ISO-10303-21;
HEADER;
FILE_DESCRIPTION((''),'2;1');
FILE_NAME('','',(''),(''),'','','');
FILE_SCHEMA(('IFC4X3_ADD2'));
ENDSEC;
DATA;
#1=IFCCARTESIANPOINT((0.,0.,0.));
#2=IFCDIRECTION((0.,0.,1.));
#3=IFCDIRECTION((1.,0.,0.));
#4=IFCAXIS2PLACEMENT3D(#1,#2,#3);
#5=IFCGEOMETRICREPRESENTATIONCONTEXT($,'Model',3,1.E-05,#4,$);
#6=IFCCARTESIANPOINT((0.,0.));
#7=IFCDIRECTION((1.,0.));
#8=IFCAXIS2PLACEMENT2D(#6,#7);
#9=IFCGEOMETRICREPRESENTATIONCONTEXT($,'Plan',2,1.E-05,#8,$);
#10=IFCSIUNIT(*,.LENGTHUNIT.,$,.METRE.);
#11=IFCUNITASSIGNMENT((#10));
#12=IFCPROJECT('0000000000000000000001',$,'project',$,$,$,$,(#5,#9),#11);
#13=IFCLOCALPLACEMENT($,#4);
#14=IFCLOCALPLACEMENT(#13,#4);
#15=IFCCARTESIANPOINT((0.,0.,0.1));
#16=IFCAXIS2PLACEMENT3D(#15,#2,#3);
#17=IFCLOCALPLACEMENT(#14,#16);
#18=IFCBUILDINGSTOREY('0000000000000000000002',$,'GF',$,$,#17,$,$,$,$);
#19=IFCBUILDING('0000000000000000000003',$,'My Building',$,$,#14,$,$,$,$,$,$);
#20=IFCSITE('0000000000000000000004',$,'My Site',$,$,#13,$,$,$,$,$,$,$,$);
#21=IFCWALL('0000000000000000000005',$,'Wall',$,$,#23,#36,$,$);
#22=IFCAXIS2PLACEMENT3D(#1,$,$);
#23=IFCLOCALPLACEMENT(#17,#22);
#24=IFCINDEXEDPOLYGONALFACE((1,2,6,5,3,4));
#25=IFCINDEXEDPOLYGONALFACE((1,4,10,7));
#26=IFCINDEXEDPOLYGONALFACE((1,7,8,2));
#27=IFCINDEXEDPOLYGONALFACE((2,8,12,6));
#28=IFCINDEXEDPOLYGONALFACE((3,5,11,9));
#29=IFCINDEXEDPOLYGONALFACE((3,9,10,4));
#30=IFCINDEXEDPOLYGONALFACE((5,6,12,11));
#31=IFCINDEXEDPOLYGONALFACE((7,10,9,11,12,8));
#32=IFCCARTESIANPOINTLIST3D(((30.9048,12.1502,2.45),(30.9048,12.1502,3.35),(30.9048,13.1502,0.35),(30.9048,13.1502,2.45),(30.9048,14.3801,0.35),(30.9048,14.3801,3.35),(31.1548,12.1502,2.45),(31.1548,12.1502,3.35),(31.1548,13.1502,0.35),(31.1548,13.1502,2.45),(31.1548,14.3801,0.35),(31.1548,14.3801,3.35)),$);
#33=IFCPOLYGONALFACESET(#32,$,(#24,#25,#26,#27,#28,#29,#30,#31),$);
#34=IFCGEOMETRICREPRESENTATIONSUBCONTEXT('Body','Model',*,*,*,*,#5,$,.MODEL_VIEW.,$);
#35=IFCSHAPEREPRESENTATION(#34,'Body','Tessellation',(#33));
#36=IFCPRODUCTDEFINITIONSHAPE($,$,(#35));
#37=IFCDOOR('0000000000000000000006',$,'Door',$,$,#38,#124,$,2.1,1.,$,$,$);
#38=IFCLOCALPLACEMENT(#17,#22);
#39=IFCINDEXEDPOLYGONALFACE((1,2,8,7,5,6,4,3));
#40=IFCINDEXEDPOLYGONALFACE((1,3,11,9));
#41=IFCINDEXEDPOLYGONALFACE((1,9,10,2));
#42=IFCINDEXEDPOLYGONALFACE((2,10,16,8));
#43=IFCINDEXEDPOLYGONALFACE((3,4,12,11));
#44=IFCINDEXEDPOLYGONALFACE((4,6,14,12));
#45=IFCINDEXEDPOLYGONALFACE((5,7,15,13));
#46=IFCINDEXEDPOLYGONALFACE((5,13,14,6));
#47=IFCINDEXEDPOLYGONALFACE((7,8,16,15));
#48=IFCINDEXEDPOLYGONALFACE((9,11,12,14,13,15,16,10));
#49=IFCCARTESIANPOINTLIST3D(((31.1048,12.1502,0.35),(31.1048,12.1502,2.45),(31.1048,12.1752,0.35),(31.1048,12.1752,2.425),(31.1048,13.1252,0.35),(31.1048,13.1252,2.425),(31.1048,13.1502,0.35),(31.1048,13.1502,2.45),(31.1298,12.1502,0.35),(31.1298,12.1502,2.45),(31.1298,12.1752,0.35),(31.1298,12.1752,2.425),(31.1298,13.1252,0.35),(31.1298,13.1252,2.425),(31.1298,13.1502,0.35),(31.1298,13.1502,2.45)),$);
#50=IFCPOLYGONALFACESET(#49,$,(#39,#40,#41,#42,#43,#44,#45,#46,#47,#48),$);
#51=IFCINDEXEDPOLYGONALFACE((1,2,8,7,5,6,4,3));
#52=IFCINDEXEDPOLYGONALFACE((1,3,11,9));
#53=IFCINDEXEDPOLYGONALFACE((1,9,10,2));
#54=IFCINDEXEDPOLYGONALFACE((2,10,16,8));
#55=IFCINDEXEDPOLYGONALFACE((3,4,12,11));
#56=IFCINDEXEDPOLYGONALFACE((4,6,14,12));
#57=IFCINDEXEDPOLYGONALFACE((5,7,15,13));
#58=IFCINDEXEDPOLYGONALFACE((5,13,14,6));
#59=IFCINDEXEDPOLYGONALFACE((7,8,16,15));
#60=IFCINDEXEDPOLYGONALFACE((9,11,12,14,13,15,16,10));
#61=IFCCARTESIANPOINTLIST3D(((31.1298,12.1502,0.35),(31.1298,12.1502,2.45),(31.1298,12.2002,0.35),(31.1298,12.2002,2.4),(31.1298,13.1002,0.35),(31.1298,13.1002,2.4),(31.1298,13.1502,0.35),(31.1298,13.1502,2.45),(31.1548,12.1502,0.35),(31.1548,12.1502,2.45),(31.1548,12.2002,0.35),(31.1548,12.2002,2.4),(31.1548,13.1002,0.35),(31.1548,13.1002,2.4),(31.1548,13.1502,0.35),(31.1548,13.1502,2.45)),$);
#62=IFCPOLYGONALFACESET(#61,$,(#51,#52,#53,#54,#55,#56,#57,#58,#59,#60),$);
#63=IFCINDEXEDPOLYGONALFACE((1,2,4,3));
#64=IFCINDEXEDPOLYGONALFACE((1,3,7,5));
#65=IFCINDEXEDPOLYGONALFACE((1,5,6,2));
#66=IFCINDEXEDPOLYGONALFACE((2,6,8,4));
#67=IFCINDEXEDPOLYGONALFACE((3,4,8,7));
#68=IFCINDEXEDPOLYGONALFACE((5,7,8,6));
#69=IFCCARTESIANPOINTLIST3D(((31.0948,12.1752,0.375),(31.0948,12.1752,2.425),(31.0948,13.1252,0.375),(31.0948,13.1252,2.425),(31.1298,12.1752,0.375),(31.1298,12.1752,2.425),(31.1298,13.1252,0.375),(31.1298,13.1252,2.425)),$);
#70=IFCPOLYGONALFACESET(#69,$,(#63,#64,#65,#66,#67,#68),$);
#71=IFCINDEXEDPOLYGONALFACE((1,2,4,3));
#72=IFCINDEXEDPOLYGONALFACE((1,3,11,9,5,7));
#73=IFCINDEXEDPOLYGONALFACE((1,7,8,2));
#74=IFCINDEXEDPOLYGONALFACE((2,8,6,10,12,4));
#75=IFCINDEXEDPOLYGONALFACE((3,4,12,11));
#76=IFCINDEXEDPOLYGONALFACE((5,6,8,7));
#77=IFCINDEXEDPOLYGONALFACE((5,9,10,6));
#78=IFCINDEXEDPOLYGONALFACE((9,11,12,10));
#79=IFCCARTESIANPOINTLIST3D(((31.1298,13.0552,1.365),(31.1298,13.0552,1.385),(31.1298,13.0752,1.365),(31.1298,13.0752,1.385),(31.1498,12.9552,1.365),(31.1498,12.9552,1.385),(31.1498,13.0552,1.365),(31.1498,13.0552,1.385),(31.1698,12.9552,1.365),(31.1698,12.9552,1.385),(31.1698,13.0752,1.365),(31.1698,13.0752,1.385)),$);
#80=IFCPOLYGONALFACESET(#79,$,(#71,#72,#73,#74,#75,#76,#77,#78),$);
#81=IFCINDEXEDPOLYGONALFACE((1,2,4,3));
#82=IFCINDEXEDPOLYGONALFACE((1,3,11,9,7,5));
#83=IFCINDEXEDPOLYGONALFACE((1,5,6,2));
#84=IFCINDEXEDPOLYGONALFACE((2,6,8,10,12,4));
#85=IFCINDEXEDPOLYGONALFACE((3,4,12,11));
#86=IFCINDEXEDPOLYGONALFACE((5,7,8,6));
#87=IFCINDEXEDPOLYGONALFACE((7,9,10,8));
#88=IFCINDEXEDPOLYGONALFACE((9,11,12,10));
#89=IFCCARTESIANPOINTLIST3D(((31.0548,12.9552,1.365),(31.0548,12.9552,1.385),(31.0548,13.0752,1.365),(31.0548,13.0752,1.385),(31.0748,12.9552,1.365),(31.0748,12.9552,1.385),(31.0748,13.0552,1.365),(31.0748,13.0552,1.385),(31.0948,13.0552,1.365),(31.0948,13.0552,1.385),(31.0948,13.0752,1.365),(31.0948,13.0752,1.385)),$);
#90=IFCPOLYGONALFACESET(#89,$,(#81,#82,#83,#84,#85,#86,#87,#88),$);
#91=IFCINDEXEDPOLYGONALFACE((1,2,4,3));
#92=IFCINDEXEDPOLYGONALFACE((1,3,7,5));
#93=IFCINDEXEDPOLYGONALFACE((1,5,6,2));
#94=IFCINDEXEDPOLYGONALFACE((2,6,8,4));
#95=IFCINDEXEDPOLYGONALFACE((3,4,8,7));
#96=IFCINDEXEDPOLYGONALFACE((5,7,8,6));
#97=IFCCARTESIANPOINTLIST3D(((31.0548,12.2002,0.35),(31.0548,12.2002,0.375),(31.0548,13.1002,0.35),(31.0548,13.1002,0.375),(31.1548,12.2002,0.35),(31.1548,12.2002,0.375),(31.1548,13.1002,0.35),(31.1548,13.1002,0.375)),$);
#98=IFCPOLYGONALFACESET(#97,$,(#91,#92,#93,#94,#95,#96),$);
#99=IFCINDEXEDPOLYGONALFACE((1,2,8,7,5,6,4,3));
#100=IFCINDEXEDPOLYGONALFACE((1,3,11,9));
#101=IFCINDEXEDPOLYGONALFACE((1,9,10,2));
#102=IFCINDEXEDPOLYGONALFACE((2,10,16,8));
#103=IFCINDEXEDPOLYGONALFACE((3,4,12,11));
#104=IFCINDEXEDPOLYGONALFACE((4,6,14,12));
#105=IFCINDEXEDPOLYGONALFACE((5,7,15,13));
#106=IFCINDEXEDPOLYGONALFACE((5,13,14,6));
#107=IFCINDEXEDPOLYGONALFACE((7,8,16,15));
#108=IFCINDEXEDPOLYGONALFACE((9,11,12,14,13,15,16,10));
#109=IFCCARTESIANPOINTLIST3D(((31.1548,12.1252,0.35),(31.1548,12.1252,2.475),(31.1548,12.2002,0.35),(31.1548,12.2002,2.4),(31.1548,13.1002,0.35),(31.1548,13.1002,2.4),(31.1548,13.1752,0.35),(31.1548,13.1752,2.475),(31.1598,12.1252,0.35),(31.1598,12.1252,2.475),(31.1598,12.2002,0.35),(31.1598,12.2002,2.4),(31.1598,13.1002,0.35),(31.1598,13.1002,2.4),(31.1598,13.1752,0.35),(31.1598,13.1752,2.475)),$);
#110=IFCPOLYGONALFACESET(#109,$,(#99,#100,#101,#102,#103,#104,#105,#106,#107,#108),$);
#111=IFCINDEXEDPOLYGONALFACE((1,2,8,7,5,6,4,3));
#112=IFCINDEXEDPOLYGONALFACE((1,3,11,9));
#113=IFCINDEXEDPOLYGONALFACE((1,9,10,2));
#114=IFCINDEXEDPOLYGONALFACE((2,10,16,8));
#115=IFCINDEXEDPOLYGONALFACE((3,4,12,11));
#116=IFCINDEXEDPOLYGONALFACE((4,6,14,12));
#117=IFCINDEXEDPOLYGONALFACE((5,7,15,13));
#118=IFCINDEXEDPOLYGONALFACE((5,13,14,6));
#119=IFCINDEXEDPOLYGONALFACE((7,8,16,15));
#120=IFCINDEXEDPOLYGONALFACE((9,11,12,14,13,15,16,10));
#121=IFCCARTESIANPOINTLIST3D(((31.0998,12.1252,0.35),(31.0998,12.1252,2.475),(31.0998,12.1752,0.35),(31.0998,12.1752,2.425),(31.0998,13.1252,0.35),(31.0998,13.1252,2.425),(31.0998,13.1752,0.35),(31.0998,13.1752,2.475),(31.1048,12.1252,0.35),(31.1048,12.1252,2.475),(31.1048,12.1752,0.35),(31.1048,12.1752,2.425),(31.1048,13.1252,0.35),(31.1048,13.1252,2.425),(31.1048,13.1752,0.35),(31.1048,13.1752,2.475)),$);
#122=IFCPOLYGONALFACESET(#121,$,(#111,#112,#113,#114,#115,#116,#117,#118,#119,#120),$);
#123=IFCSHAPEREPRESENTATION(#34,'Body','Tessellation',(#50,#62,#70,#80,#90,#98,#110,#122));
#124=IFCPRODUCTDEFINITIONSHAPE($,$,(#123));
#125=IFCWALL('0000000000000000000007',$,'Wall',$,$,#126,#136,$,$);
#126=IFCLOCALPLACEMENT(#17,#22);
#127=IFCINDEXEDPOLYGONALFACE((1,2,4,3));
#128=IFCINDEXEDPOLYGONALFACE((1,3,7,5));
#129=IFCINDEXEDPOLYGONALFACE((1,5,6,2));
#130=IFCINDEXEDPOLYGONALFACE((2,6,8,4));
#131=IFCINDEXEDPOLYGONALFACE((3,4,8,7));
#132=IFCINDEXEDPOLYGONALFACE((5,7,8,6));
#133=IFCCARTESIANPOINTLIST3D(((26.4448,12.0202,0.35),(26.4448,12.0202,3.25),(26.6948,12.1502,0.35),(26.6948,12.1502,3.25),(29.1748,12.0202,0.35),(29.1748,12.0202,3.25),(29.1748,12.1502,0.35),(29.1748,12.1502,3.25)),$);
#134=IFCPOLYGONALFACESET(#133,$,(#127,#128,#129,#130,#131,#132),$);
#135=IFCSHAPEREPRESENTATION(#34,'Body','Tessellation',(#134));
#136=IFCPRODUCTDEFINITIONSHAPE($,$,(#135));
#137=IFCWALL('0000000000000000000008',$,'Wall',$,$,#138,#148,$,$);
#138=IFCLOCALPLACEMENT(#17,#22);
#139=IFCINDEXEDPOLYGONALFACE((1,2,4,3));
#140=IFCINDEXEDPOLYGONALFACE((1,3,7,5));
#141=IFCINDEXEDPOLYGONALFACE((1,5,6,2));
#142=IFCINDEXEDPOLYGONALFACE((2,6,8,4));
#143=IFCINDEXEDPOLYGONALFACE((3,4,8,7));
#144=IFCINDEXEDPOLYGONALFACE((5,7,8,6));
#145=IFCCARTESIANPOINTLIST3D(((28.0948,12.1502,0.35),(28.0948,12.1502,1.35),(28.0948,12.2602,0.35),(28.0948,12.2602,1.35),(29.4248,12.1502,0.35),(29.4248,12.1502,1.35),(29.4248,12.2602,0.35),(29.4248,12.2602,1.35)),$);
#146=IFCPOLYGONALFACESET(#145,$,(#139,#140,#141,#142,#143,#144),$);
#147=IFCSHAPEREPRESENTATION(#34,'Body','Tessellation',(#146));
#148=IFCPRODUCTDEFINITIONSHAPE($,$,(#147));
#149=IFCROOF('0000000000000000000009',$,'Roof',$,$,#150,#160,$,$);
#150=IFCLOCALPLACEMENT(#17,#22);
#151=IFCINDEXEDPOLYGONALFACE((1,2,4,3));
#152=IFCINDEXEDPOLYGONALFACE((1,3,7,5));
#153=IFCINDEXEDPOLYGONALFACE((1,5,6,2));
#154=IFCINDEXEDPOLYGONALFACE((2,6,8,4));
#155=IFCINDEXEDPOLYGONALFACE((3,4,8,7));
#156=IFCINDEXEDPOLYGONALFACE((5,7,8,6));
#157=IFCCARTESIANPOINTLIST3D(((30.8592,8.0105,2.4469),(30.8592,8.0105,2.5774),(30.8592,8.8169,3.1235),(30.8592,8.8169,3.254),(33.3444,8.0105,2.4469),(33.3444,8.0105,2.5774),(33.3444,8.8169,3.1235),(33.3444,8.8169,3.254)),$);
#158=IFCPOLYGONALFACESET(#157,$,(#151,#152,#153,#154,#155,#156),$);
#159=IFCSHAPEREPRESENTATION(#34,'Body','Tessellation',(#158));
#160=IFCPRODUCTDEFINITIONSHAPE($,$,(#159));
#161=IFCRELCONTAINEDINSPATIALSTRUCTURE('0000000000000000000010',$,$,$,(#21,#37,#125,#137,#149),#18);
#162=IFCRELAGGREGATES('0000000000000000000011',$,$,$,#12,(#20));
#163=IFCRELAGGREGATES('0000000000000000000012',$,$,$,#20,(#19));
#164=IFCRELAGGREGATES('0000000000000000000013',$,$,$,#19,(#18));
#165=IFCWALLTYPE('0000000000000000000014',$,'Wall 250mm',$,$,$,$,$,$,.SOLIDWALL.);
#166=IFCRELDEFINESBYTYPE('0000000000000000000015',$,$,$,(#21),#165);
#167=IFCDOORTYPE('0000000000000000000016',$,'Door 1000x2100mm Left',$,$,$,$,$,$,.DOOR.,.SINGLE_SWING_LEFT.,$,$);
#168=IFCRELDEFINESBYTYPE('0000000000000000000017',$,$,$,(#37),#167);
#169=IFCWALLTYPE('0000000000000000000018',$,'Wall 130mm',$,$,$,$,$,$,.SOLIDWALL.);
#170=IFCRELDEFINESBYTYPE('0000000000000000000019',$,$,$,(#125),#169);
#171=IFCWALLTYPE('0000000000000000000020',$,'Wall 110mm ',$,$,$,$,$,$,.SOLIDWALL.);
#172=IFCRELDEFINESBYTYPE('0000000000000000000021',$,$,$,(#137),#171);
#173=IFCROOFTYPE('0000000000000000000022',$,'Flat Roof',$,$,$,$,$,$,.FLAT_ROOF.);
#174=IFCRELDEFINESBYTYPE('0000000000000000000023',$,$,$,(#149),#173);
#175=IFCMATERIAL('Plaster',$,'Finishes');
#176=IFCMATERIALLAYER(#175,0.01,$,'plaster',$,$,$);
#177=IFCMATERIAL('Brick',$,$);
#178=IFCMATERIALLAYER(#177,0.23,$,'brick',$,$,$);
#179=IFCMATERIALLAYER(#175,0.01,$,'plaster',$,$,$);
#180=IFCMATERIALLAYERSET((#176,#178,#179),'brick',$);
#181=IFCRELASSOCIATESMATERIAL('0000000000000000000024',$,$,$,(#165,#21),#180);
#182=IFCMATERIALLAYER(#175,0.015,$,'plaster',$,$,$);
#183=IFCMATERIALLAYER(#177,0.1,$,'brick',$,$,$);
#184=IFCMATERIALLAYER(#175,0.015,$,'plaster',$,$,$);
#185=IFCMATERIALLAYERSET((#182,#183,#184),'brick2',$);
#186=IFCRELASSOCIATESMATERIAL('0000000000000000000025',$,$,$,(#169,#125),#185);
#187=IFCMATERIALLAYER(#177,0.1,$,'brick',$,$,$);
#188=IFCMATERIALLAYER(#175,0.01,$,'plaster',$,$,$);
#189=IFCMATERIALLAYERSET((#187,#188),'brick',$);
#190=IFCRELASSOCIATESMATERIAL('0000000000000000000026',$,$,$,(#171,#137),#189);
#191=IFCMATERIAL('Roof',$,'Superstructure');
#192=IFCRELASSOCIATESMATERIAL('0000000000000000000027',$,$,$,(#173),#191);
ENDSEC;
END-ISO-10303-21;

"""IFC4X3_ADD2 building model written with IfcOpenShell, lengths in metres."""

from ifc_helpers import new_model, entity, si_unit, frame, origin_with_axes, origin_2d_with_axis, place, context, subcontext, project, spatial, line, indexed_curve, outline, extrude, shape, source, transform, mapped, material, layer, layer_set, layer_usage, type_object, type_shapes, element, fill, save


model = new_model("IFC4X3_ADD2")

# Units and contexts
model_context = context("Model", 3, precision=1e-05, world=origin_with_axes())
plan_context = context("Plan", 2, precision=1e-05, world=origin_2d_with_axis())
body_context_1 = subcontext(model_context, "Body", "Model", "MODEL_VIEW")
body_context_2 = subcontext(plan_context, "Body", "Plan", "PLAN_VIEW")
ifc_project = project(units=[si_unit("LENGTHUNIT", "METRE")], contexts=[model_context, plan_context])

# Site, building, storey
site_placement = place(None, origin_with_axes())
site = spatial("IfcSite", under=ifc_project, at=site_placement, Name="My Site")
building_placement = place(site_placement, origin_with_axes())
building = spatial("IfcBuilding", under=site, at=building_placement, Name="My Building")
storey_placement = place(building_placement, frame((0.0, 0.0, 0.1), z_axis=(0.0, 0.0, 1.0), x_axis=(1.0, 0.0, 0.0)))
storey = spatial("IfcBuildingStorey", under=building, at=storey_placement, Name="GF")

# Shared definitions
ifc_material_1 = material(Name="Plaster", Category="Finishes")
ifc_layer_1 = layer(ifc_material_1, 0.01, Name="plaster")
ifc_material_2 = material(Name="Brick")
ifc_layer_2 = layer(ifc_material_2, 0.23, Name="brick")
ifc_layer_3 = layer(ifc_material_1, 0.01, Name="plaster")
ifc_layer_set_1 = layer_set([ifc_layer_1, ifc_layer_2, ifc_layer_3], Name="brick")
wall_type_1 = type_object("IfcWallType", Name="Wall 250mm", PredefinedType="SOLIDWALL", material=ifc_layer_set_1)

# Wall, opening, door
ifc_layer_usage_1 = layer_usage(ifc_layer_set_1, "AXIS2", "POSITIVE", 0.0)
wall_1_placement = place(storey_placement, frame((31.1548, 12.1502, 0.35), z_axis=(0.0, 0.0, 1.0), x_axis=(0.000001, 1.0, 0.0)))
wall_1 = element("IfcWall", 1, at=wall_1_placement, inside=storey, type_object=wall_type_1, material=ifc_layer_usage_1, Name="Wall", context=body_context_1, shape_type="SweptSolid", body=[
    extrude(outline(indexed_curve([(0.0, 0.0), (0.0, 0.25), (2.2299, 0.25), (2.2299, 0.0)], segments=[line(1, 2, 3, 4, 1)])), origin_with_axes(), (0.0, 0.0, 1.0), 3.0),
])
shared_shape_1 = source(origin_with_axes(), body_context_1, "Body", "SweptSolid", [
    extrude(outline(indexed_curve([(0.0, 0.0), (1.0, 0.0), (1.0, 2.1), (0.0, 2.1)], segments=[line(1, 2, 3, 4, 1)])), frame((0.0, -0.6, 0.0), z_axis=(0.0, -1.0, 0.0), x_axis=(1.0, 0.0, 0.0)), (0.0, 0.0, -1.0), 1.2),
])
opening_1_placement = place(wall_1_placement, frame((0.0, 0.0, 0.0), z_axis=(0.0, 0.0, 1.0), x_axis=(1.0, 0.0, 0.0)))
opening_1 = element("IfcOpeningElement", 2, at=opening_1_placement, cuts=wall_1, PredefinedType="OPENING", context=body_context_1, shape_type="MappedRepresentation", body=[
    mapped(shared_shape_1, transform((0.0, 0.0, 0.0), x_axis=(1.0, 0.0, 0.0), y_axis=(0.0, 1.0, 0.0), z_axis=(0.0, 0.0, 1.0), scale=1.0)),
])
door_type_1 = type_object("IfcDoorType", Name="Door 1000x2100mm Left", OperationType="SINGLE_SWING_LEFT", PredefinedType="DOOR")
shared_shape_2 = source(origin_with_axes(), body_context_1, "Body", "SweptSolid", [
    extrude(outline(indexed_curve([(0.0, 0.0), (0.0, 2.1), (1.0, 2.1), (1.0, 0.0), (0.975, 0.0), (0.975, 2.075), (0.025, 2.075), (0.025, 0.0)], segments=[line(1, 2, 3, 4, 5, 6, 7, 8, 1)])), frame((0.0, 0.025, 0.0), z_axis=(0.0, -1.0, 0.0), x_axis=(1.0, 0.0, 0.0)), (0.0, 0.0, -1.0), 0.025),
    extrude(outline(indexed_curve([(0.0, 0.0), (0.0, 2.1), (1.0, 2.1), (1.0, 0.0), (0.95, 0.0), (0.95, 2.05), (0.05, 2.05), (0.05, 0.0)], segments=[line(1, 2, 3, 4, 5, 6, 7, 8, 1)])), frame((0.0, 0.0, 0.0), z_axis=(0.0, -1.0, 0.0), x_axis=(1.0, 0.0, 0.0)), (0.0, 0.0, -1.0), 0.025),
    extrude(outline(indexed_curve([(0.0, 0.0), (0.95, 0.0), (0.95, 0.035), (0.0, 0.035)], segments=[line(1, 2, 3, 4, 1)])), frame((0.025, 0.025, 0.025), z_axis=(0.0, 0.0, 1.0), x_axis=(1.0, 0.0, 0.0)), (0.0, 0.0, 1.0), 2.05),
    extrude(outline(indexed_curve([(0.0, 0.0), (0.0, -0.04), (-0.12, -0.04), (-0.12, -0.02), (-0.02, -0.02), (-0.02, 0.0)], segments=[line(1, 2, 3, 4, 5, 6, 1)])), frame((0.925, 0.025, 1.015), z_axis=(0.0, 0.0, 1.0), x_axis=(1.0, 0.0, 0.0)), (0.0, 0.0, 1.0), 0.02),
    extrude(outline(indexed_curve([(0.0, 0.0), (0.0, 0.04), (-0.12, 0.04), (-0.12, 0.02), (-0.02, 0.02), (-0.02, 0.0)], segments=[line(1, 2, 3, 4, 5, 6, 1)])), frame((0.925, 0.06, 1.015), z_axis=(0.0, 0.0, 1.0), x_axis=(1.0, 0.0, 0.0)), (0.0, 0.0, 1.0), 0.02),
    extrude(outline(indexed_curve([(0.0, 0.0), (0.9, 0.0), (0.9, 0.1), (0.0, 0.1)], segments=[line(1, 2, 3, 4, 1)])), frame((0.05, 0.0, 0.0), z_axis=(0.0, 0.0, 1.0), x_axis=(1.0, 0.0, 0.0)), (0.0, 0.0, 1.0), 0.025),
    extrude(outline(indexed_curve([(0.0, 0.0), (0.0, 2.125), (1.05, 2.125), (1.05, 0.0), (0.975, 0.0), (0.975, 2.05), (0.075, 2.05), (0.075, 0.0)], segments=[line(1, 2, 3, 4, 5, 6, 7, 8, 1)])), frame((-0.025, -0.005, 0.0), z_axis=(0.0, -1.0, 0.0), x_axis=(1.0, 0.0, 0.0)), (0.0, 0.0, -1.0), 0.005),
    extrude(outline(indexed_curve([(0.0, 0.0), (0.0, 2.125), (1.05, 2.125), (1.05, 0.0), (1.0, 0.0), (1.0, 2.075), (0.05, 2.075), (0.05, 0.0)], segments=[line(1, 2, 3, 4, 5, 6, 7, 8, 1)])), frame((-0.025, 0.05, 0.0), z_axis=(0.0, -1.0, 0.0), x_axis=(1.0, 0.0, 0.0)), (0.0, 0.0, -1.0), 0.005),
])
shared_shape_3 = source(origin_with_axes(), body_context_2, "Body", "Curve2D", [
    entity("IfcIndexedPolyCurve", entity("IfcCartesianPointList2D", [[0.0, 0.0], [0.0, 0.05], [0.025, 0.05], [0.025, 0.025], [0.05, 0.025], [0.05, 0.0]]), [entity("IfcLineIndex", [1, 2, 3, 4, 5, 6, 1])]),
    entity("IfcIndexedPolyCurve", entity("IfcCartesianPointList2D", [[1.0, 0.0], [1.0, 0.05], [0.975, 0.05], [0.975, 0.025], [0.95, 0.025], [0.95, 0.0]]), [entity("IfcLineIndex", [1, 2, 3, 4, 5, 6, 1])]),
    entity("IfcTrimmedCurve", entity("IfcEllipse", entity("IfcAxis2Placement2D", entity("IfcCartesianPoint", [0.06, 0.05]), entity("IfcDirection", [1.0, 0.0])), 0.915, 0.95), [entity("IfcCartesianPoint", [0.975, 0.05])], [entity("IfcCartesianPoint", [0.06, 1.0])], True, "CARTESIAN"),
    entity("IfcIndexedPolyCurve", entity("IfcCartesianPointList2D", [[0.025, 0.05], [0.06, 0.05], [0.06, 1.0], [0.025, 1.0]]), [entity("IfcLineIndex", [1, 2, 3, 4, 1])]),
])
type_shapes(door_type_1, [shared_shape_2, shared_shape_3])
door_1_placement = place(opening_1_placement, frame((0.0, 0.0, 0.0), z_axis=(0.0, 0.0, 1.0), x_axis=(1.0, 0.0, 0.0)))
door_1 = element("IfcDoor", 3, at=door_1_placement, inside=storey, type_object=door_type_1, Name="Door", OverallHeight=2.1, OverallWidth=1.0, shapes=[
    shape(body_context_1, "Body", "MappedRepresentation", [mapped(shared_shape_2, transform((0.0, 0.0, 0.0), x_axis=(1.0, 0.0, 0.0), y_axis=(0.0, 1.0, 0.0), z_axis=(0.0, 0.0, 1.0), scale=1.0))]),
    shape(body_context_2, "Body", "MappedRepresentation", [mapped(shared_shape_3, transform((0.0, 0.0, 0.0), x_axis=(1.0, 0.0, 0.0), y_axis=(0.0, 1.0, 0.0), z_axis=(0.0, 0.0, 1.0), scale=1.0))]),
])
fill(opening_1, door_1)

# Walls
ifc_layer_4 = layer(ifc_material_1, 0.015, Name="plaster")
ifc_layer_5 = layer(ifc_material_2, 0.1, Name="brick")
ifc_layer_6 = layer(ifc_material_1, 0.015, Name="plaster")
ifc_layer_set_2 = layer_set([ifc_layer_4, ifc_layer_5, ifc_layer_6], Name="brick2")
ifc_layer_usage_2 = layer_usage(ifc_layer_set_2, "AXIS2", "POSITIVE", 0.0)
wall_type_2 = type_object("IfcWallType", Name="Wall 130mm", PredefinedType="SOLIDWALL", material=ifc_layer_set_2)
wall_2_placement = place(storey_placement, frame((29.4248, 12.1502, 0.35), z_axis=(0.0, 0.0, 1.0), x_axis=(-1.0, 0.0, 0.0)))
element("IfcWall", 4, at=wall_2_placement, inside=storey, type_object=wall_type_2, material=ifc_layer_usage_2, Name="Wall", context=body_context_1, shape_type="SweptSolid", body=[
    extrude(outline(indexed_curve([(0.25, 0.0), (0.25, 0.13), (2.98, 0.13), (2.73, 0.0)], segments=[line(1, 2, 3, 4, 1)])), origin_with_axes(), (0.0, 0.0, 1.0), 2.9),
])
ifc_layer_7 = layer(ifc_material_2, 0.1, Name="brick")
ifc_layer_8 = layer(ifc_material_1, 0.01, Name="plaster")
ifc_layer_set_3 = layer_set([ifc_layer_7, ifc_layer_8], Name="brick")
ifc_layer_usage_3 = layer_usage(ifc_layer_set_3, "AXIS2", "NEGATIVE", 0.0)
wall_type_3 = type_object("IfcWallType", Name="Wall 110mm ", PredefinedType="SOLIDWALL", material=ifc_layer_set_3)
wall_3_placement = place(storey_placement, frame((29.4248, 12.1502, 0.35), z_axis=(0.0, 0.0, 1.0), x_axis=(-1.0, 0.0, 0.0)))
element("IfcWall", 5, at=wall_3_placement, inside=storey, type_object=wall_type_3, material=ifc_layer_usage_3, Name="Wall", context=body_context_1, shape_type="SweptSolid", body=[
    extrude(outline(indexed_curve([(0.0, -0.11), (0.0, 0.0), (1.33, 0.0), (1.33, -0.11)], segments=[line(1, 2, 3, 4, 1)])), origin_with_axes(), (0.0, 0.0, 1.0), 1.0),
])

# Roof
ifc_material_3 = material(Name="Roof", Category="Superstructure")
roof_type = type_object("IfcRoofType", Name="Flat Roof", PredefinedType="FLAT_ROOF", material=ifc_material_3)
roof_placement = place(storey_placement, frame((30.8592, 8.0241, 2.4583), z_axis=(0.0, -0.642788, 0.766044), x_axis=(1.0, 0.0, 0.0)))
element("IfcRoof", 6, at=roof_placement, inside=storey, type_object=roof_type, Name="Roof", context=body_context_1, shape_type="SweptSolid", body=[
    extrude(outline(indexed_curve([(1.2426, 0.0653), (1.2426, -0.0653), (-1.2426, -0.0653), (-1.2426, 0.0653)])), frame((1.2426, 1.0768, 0.05), z_axis=(0.0, 0.766044, -0.642788), x_axis=(1.0, 0.0, 0.0)), (0.0, 0.642788, -0.766044), 1.0526),
])

save(model, "model.ifc")
